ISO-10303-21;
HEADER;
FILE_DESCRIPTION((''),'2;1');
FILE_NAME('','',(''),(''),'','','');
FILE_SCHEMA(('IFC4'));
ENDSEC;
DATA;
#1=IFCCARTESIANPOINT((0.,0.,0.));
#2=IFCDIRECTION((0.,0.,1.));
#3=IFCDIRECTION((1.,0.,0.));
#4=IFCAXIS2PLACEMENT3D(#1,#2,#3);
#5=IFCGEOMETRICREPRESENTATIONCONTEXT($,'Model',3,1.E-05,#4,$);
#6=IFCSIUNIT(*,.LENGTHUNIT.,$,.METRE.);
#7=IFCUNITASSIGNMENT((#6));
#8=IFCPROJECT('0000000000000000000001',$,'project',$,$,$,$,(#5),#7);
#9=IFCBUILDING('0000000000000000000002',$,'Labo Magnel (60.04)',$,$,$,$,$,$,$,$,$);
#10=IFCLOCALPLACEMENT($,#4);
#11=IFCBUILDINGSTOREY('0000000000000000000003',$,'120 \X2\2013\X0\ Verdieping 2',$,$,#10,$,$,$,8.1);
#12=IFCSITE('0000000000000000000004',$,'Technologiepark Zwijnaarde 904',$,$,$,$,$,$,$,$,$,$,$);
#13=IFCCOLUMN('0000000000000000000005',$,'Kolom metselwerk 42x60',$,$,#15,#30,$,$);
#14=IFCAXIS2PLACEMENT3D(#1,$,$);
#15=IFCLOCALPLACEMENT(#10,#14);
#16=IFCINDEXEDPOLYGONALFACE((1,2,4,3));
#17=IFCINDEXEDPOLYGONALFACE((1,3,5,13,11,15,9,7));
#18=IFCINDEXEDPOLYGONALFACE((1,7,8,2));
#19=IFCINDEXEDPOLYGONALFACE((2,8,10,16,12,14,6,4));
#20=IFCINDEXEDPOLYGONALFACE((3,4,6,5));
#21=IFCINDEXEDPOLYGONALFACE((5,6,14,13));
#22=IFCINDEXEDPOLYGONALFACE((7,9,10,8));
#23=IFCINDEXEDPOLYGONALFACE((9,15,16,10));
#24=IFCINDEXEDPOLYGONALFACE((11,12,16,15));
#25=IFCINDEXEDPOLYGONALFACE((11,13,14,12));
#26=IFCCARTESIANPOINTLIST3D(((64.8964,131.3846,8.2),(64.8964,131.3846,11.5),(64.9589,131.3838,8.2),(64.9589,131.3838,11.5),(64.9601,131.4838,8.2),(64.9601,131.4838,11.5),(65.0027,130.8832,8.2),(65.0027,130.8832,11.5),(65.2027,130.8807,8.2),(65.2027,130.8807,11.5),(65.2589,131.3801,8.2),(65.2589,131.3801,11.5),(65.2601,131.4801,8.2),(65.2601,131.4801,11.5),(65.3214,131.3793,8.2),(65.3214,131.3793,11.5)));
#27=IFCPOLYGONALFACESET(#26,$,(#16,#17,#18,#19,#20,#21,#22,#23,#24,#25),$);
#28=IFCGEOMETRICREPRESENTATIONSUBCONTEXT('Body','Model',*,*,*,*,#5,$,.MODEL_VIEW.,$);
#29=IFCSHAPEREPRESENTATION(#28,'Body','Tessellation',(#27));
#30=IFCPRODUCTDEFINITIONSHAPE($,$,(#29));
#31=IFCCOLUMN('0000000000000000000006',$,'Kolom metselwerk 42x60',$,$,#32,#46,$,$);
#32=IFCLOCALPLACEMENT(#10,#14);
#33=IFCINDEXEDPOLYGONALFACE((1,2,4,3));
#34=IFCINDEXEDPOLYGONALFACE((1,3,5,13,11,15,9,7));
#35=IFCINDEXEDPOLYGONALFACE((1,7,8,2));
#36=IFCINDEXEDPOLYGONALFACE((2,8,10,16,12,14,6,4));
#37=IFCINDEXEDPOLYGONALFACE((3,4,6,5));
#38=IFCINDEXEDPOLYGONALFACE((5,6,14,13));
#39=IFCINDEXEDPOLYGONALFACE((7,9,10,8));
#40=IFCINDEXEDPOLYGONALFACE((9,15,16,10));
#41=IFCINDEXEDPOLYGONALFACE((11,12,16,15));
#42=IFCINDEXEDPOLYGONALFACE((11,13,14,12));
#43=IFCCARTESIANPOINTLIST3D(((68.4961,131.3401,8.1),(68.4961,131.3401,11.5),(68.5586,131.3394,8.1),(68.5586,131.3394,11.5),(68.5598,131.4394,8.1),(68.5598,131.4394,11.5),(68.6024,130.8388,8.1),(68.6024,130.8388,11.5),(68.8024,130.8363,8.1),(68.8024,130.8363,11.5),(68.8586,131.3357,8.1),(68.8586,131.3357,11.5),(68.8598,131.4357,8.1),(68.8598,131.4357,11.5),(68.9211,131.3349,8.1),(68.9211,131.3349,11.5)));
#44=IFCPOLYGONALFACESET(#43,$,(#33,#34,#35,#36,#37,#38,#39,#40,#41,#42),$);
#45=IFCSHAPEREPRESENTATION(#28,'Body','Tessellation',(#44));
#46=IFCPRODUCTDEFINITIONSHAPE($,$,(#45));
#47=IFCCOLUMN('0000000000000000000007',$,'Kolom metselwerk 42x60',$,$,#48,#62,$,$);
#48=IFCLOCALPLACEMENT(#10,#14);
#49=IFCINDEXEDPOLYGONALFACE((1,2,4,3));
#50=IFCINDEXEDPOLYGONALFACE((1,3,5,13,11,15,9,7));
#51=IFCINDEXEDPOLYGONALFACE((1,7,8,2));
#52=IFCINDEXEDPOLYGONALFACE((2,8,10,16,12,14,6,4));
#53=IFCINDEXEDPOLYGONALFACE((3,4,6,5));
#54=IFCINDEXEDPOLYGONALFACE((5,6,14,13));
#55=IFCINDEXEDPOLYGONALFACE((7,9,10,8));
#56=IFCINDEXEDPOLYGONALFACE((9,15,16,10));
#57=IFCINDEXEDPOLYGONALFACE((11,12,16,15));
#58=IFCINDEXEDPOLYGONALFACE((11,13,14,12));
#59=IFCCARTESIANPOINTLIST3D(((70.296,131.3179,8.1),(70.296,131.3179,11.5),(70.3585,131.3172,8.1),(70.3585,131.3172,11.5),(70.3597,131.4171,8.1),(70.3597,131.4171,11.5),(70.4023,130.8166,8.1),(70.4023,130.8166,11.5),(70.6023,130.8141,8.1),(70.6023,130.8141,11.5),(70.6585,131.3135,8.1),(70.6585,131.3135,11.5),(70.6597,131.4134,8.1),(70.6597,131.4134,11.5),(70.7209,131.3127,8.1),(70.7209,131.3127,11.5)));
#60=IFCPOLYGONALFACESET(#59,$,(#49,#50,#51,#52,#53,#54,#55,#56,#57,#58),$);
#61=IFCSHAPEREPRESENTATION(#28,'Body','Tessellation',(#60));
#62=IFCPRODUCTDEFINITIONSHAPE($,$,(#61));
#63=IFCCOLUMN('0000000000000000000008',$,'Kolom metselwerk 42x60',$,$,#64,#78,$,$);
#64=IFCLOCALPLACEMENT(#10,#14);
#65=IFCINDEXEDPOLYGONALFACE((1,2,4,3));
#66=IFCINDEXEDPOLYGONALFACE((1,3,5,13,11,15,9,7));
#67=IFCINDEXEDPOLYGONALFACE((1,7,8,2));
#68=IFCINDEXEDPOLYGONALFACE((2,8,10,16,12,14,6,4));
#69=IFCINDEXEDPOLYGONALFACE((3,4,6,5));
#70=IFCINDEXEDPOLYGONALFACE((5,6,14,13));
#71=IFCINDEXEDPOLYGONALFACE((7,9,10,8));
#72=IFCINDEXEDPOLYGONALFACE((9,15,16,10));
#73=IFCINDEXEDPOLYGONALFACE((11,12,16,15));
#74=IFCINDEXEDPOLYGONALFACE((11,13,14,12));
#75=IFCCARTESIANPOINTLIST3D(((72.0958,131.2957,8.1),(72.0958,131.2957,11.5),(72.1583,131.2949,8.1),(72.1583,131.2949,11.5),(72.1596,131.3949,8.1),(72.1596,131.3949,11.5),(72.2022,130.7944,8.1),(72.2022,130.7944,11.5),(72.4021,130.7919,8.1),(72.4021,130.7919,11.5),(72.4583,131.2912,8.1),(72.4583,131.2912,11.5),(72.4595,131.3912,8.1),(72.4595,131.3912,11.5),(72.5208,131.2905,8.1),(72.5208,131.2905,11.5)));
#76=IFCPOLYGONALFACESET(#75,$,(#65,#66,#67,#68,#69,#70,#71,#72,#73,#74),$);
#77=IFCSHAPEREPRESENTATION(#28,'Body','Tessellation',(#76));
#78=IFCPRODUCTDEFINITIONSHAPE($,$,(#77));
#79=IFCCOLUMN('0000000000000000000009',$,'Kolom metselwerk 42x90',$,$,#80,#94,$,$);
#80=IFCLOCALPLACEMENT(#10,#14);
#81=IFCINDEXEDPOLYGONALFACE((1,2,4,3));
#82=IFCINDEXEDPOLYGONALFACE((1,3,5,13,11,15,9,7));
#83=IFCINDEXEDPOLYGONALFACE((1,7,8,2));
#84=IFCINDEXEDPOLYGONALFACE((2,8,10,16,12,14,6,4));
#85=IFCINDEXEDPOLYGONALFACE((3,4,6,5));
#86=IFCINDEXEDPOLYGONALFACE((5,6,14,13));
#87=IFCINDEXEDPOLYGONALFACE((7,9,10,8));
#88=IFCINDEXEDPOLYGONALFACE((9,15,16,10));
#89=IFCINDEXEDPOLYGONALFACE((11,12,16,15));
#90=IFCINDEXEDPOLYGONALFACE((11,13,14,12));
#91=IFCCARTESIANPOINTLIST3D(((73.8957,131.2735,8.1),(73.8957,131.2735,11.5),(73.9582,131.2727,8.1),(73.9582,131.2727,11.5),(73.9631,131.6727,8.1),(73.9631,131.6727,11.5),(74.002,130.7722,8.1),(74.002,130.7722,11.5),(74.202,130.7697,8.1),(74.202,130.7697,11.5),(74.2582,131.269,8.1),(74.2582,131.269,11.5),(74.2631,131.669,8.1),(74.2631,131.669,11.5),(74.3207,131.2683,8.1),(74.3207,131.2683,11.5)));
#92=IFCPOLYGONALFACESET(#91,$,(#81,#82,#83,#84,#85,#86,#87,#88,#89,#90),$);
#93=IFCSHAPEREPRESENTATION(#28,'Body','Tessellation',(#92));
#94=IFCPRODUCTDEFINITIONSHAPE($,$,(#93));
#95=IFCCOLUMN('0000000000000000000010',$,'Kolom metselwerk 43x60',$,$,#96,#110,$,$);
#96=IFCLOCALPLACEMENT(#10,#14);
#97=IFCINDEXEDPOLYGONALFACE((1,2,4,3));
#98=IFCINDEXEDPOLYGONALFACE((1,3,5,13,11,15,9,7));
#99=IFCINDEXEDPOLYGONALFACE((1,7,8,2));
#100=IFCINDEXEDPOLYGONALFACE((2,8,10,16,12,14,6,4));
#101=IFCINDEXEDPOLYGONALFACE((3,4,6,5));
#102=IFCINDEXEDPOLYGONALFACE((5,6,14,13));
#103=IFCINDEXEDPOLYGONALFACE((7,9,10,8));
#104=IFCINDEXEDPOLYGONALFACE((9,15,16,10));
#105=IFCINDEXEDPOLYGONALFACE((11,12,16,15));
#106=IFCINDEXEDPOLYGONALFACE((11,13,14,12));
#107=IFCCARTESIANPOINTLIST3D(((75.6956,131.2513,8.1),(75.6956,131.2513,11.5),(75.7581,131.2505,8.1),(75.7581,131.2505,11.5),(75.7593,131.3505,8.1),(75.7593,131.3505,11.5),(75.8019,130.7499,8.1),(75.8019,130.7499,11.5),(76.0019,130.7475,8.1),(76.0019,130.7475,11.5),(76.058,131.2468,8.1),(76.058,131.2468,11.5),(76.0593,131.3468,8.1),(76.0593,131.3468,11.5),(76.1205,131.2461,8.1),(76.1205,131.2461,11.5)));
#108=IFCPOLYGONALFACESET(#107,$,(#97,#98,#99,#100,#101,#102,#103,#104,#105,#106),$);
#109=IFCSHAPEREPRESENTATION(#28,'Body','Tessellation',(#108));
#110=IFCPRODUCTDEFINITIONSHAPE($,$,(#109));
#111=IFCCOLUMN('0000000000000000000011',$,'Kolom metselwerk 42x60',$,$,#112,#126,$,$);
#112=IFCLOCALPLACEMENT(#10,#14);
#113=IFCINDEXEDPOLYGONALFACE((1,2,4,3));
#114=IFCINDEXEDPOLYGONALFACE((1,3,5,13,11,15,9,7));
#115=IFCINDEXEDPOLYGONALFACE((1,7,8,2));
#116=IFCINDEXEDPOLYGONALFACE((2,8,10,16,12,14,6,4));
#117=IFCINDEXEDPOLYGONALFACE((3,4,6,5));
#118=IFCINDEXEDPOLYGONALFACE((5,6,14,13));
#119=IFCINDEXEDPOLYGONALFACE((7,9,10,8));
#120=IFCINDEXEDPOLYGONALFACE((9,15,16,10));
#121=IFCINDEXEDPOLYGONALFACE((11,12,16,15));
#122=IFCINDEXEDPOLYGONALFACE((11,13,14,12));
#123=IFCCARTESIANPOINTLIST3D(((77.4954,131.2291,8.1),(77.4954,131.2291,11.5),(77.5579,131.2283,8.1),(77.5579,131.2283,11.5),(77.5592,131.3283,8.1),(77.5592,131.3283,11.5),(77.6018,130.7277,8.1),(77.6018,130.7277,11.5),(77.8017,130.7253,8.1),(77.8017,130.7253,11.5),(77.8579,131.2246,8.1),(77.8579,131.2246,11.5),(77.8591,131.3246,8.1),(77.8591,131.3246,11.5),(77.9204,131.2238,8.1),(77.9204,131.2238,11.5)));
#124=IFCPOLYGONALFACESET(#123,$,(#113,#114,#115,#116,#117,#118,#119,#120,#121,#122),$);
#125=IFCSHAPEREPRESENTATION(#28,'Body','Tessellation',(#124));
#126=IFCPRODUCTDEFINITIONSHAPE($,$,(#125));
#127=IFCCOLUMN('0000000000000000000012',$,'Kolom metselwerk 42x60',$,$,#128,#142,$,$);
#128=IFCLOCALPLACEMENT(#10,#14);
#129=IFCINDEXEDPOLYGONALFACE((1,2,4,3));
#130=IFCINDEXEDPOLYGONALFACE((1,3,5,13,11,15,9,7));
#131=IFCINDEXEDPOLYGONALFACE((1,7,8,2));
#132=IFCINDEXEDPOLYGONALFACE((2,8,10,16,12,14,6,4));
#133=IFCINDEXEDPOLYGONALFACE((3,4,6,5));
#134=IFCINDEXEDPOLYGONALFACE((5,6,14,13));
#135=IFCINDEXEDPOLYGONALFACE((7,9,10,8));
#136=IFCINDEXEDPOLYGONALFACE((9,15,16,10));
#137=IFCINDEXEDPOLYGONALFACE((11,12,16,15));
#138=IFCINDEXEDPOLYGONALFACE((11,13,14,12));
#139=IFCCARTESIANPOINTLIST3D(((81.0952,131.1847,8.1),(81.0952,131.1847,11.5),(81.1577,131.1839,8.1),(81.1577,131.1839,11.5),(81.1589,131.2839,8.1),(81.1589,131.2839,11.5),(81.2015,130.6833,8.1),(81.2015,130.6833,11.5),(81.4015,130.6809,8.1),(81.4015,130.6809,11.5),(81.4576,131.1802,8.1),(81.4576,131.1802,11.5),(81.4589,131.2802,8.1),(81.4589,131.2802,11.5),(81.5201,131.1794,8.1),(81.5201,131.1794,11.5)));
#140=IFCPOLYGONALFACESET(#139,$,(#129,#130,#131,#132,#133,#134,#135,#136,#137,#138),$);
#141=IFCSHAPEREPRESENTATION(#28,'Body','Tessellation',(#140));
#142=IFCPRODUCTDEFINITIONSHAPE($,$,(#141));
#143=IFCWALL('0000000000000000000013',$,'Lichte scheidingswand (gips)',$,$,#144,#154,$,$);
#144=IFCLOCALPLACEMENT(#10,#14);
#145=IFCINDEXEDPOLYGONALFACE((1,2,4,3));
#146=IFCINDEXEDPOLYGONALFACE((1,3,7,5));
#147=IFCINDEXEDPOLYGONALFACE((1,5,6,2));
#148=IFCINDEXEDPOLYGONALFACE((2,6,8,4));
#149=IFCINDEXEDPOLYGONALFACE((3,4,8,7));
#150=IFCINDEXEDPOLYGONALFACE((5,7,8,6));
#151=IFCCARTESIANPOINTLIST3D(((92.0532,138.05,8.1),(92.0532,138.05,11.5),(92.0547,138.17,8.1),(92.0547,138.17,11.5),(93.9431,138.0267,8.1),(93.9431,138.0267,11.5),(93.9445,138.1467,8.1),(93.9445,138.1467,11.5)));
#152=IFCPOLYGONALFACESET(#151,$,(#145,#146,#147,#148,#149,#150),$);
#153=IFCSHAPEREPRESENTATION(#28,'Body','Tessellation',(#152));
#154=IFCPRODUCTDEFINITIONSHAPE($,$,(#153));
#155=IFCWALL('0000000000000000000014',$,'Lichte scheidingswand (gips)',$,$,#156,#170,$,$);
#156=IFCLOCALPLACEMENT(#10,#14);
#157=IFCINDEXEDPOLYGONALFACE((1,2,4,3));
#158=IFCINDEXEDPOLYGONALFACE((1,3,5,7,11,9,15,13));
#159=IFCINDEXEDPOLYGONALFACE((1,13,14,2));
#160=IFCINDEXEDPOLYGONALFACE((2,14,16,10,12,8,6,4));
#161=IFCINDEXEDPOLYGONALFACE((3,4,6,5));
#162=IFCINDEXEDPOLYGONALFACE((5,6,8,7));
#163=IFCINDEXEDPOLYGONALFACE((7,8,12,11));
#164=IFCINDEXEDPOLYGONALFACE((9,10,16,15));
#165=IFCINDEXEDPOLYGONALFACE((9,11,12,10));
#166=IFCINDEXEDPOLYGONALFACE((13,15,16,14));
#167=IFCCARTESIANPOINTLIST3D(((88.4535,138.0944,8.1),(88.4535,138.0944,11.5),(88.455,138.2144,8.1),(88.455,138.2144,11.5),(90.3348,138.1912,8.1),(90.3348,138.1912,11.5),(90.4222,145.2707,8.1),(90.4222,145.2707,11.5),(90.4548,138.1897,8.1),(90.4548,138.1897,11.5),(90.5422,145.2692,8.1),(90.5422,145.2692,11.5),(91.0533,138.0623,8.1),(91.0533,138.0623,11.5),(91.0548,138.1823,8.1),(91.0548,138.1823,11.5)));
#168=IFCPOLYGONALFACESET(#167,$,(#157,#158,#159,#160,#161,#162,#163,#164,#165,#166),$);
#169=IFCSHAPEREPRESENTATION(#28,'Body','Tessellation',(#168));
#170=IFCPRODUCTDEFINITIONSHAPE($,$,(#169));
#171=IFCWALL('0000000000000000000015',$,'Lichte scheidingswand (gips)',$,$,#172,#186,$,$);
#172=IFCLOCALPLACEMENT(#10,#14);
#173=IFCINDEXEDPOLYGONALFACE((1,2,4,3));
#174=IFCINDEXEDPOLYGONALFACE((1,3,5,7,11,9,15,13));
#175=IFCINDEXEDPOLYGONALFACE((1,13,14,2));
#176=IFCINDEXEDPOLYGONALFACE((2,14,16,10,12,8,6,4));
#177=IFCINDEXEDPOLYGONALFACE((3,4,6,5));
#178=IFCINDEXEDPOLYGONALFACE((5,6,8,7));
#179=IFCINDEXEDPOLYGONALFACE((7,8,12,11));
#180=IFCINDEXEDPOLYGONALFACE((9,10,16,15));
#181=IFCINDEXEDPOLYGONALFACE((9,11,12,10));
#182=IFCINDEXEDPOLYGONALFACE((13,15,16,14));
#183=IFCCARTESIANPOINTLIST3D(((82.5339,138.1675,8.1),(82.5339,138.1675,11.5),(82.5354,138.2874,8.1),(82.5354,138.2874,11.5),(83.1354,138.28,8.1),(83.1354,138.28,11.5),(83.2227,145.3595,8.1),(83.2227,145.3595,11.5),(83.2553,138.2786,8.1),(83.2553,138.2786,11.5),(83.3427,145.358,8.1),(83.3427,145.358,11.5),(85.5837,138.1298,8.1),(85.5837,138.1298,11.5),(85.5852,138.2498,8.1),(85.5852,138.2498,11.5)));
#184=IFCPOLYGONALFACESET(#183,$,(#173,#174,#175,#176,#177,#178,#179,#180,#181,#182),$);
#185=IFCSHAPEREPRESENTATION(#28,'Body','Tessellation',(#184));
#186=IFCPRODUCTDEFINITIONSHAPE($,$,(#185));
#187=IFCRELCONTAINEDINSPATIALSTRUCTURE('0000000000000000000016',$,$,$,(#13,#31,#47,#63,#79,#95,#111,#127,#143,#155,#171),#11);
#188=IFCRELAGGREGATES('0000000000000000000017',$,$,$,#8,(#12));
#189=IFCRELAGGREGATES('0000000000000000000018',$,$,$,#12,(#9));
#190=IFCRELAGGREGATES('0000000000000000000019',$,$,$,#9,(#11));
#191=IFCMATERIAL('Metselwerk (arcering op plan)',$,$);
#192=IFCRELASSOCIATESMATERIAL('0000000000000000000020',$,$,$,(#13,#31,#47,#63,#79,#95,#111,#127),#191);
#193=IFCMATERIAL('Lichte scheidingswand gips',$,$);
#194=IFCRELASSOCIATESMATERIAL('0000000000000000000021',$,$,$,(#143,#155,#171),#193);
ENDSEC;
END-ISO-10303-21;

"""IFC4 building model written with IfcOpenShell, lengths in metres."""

from ifc_helpers import new_model, si_unit, frame, origin, origin_with_axes, place, context, subcontext, project, spatial, polyline, outline, extrude, material, element, save


model = new_model("IFC4")

# Units and contexts
model_context = context("Model", 3, precision=1e-05, world=origin_with_axes())
body_context = subcontext(model_context, "Body", "Model", "MODEL_VIEW")
ifc_project = project(units=[si_unit("LENGTHUNIT", "METRE")], contexts=[model_context])

# Site, building, storey
site = spatial("IfcSite", under=ifc_project, Name="Technologiepark Zwijnaarde 904")
building = spatial("IfcBuilding", under=site, Name="Labo Magnel (60.04)")
storey_placement = place(None, origin_with_axes())
storey = spatial("IfcBuildingStorey", under=building, at=storey_placement, Name="120 – Verdieping 2", Elevation=8.1)

# Columns
ifc_material_1 = material(Name="Metselwerk (arcering op plan)")
column_1_placement = place(storey_placement, frame((0.0, 0.0, 8.2), z_axis=(0.0, 0.0, 1.0), x_axis=(1.0, 0.0, 0.0)))
element("IfcColumn", 1, at=column_1_placement, inside=storey, material=ifc_material_1, Name="Kolom metselwerk 42x60", context=body_context, shape_type="SweptSolid", body=[
    extrude(outline(polyline([(65.3214, 131.3793), (65.2589, 131.3801), (65.2601, 131.4801), (64.9601, 131.4838), (64.9589, 131.3838), (64.8964, 131.3846), (65.0027, 130.8832), (65.2027, 130.8807), (65.3214, 131.3793)])), origin(), (0.0, 0.0, 1.0), 3.3),
])
column_2_placement = place(storey_placement, frame((0.0, 0.0, 8.1), z_axis=(0.0, 0.0, 1.0), x_axis=(1.0, 0.0, 0.0)))
element("IfcColumn", 2, at=column_2_placement, inside=storey, material=ifc_material_1, Name="Kolom metselwerk 42x60", context=body_context, shape_type="SweptSolid", body=[
    extrude(outline(polyline([(68.9211, 131.3349), (68.8586, 131.3357), (68.8598, 131.4357), (68.5598, 131.4394), (68.5586, 131.3394), (68.4961, 131.3401), (68.6024, 130.8388), (68.8024, 130.8363), (68.9211, 131.3349)])), origin(), (0.0, 0.0, 1.0), 3.4),
])
column_3_placement = place(storey_placement, frame((0.0, 0.0, 8.1), z_axis=(0.0, 0.0, 1.0), x_axis=(1.0, 0.0, 0.0)))
element("IfcColumn", 3, at=column_3_placement, inside=storey, material=ifc_material_1, Name="Kolom metselwerk 42x60", context=body_context, shape_type="SweptSolid", body=[
    extrude(outline(polyline([(70.7209, 131.3127), (70.6585, 131.3135), (70.6597, 131.4134), (70.3597, 131.4171), (70.3585, 131.3172), (70.296, 131.3179), (70.4023, 130.8166), (70.6023, 130.8141), (70.7209, 131.3127)])), origin(), (0.0, 0.0, 1.0), 3.4),
])
column_4_placement = place(storey_placement, frame((0.0, 0.0, 8.1), z_axis=(0.0, 0.0, 1.0), x_axis=(1.0, 0.0, 0.0)))
element("IfcColumn", 4, at=column_4_placement, inside=storey, material=ifc_material_1, Name="Kolom metselwerk 42x60", context=body_context, shape_type="SweptSolid", body=[
    extrude(outline(polyline([(72.5208, 131.2905), (72.4583, 131.2912), (72.4595, 131.3912), (72.1596, 131.3949), (72.1583, 131.2949), (72.0958, 131.2957), (72.2022, 130.7944), (72.4021, 130.7919), (72.5208, 131.2905)])), origin(), (0.0, 0.0, 1.0), 3.4),
])
column_5_placement = place(storey_placement, frame((0.0, 0.0, 8.1), z_axis=(0.0, 0.0, 1.0), x_axis=(1.0, 0.0, 0.0)))
element("IfcColumn", 5, at=column_5_placement, inside=storey, material=ifc_material_1, Name="Kolom metselwerk 42x90", context=body_context, shape_type="SweptSolid", body=[
    extrude(outline(polyline([(74.3207, 131.2683), (74.2582, 131.269), (74.2631, 131.669), (73.9631, 131.6727), (73.9582, 131.2727), (73.8957, 131.2735), (74.002, 130.7722), (74.202, 130.7697), (74.3207, 131.2683)])), origin(), (0.0, 0.0, 1.0), 3.4),
])
column_6_placement = place(storey_placement, frame((0.0, 0.0, 8.1), z_axis=(0.0, 0.0, 1.0), x_axis=(1.0, 0.0, 0.0)))
element("IfcColumn", 6, at=column_6_placement, inside=storey, material=ifc_material_1, Name="Kolom metselwerk 43x60", context=body_context, shape_type="SweptSolid", body=[
    extrude(outline(polyline([(76.1205, 131.2461), (76.058, 131.2468), (76.0593, 131.3468), (75.7593, 131.3505), (75.7581, 131.2505), (75.6956, 131.2513), (75.8019, 130.7499), (76.0019, 130.7475), (76.1205, 131.2461)])), origin(), (0.0, 0.0, 1.0), 3.4),
])
column_7_placement = place(storey_placement, frame((0.0, 0.0, 8.1), z_axis=(0.0, 0.0, 1.0), x_axis=(1.0, 0.0, 0.0)))
element("IfcColumn", 7, at=column_7_placement, inside=storey, material=ifc_material_1, Name="Kolom metselwerk 42x60", context=body_context, shape_type="SweptSolid", body=[
    extrude(outline(polyline([(77.9204, 131.2238), (77.8579, 131.2246), (77.8591, 131.3246), (77.5592, 131.3283), (77.5579, 131.2283), (77.4954, 131.2291), (77.6018, 130.7277), (77.8017, 130.7253), (77.9204, 131.2238)])), origin(), (0.0, 0.0, 1.0), 3.4),
])
column_8_placement = place(storey_placement, frame((0.0, 0.0, 8.1), z_axis=(0.0, 0.0, 1.0), x_axis=(1.0, 0.0, 0.0)))
element("IfcColumn", 8, at=column_8_placement, inside=storey, material=ifc_material_1, Name="Kolom metselwerk 42x60", context=body_context, shape_type="SweptSolid", body=[
    extrude(outline(polyline([(81.5201, 131.1794), (81.4576, 131.1802), (81.4589, 131.2802), (81.1589, 131.2839), (81.1577, 131.1839), (81.0952, 131.1847), (81.2015, 130.6833), (81.4015, 130.6809), (81.5201, 131.1794)])), origin(), (0.0, 0.0, 1.0), 3.4),
])

# Walls
ifc_material_2 = material(Name="Lichte scheidingswand gips")
wall_1_placement = place(storey_placement, frame((0.0, 0.0, 8.1), z_axis=(0.0, 0.0, 1.0), x_axis=(1.0, 0.0, 0.0)))
element("IfcWall", 9, at=wall_1_placement, inside=storey, material=ifc_material_2, Name="Lichte scheidingswand (gips)", context=body_context, shape_type="SweptSolid", body=[
    extrude(outline(polyline([(93.9445, 138.1467), (92.0547, 138.17), (92.0532, 138.05), (93.9431, 138.0267), (93.9445, 138.1467)])), origin(), (0.0, 0.0, 1.0), 3.4),
])
wall_2_placement = place(storey_placement, frame((0.0, 0.0, 8.1), z_axis=(0.0, 0.0, 1.0), x_axis=(1.0, 0.0, 0.0)))
element("IfcWall", 10, at=wall_2_placement, inside=storey, material=ifc_material_2, Name="Lichte scheidingswand (gips)", context=body_context, shape_type="SweptSolid", body=[
    extrude(outline(polyline([(88.455, 138.2144), (88.4535, 138.0944), (91.0533, 138.0623), (91.0548, 138.1823), (90.4548, 138.1897), (90.5422, 145.2692), (90.4222, 145.2707), (90.3348, 138.1912), (88.455, 138.2144)])), origin(), (0.0, 0.0, 1.0), 3.4),
])
wall_3_placement = place(storey_placement, frame((0.0, 0.0, 8.1), z_axis=(0.0, 0.0, 1.0), x_axis=(1.0, 0.0, 0.0)))
element("IfcWall", 11, at=wall_3_placement, inside=storey, material=ifc_material_2, Name="Lichte scheidingswand (gips)", context=body_context, shape_type="SweptSolid", body=[
    extrude(outline(polyline([(82.5354, 138.2874), (82.5339, 138.1675), (85.5837, 138.1298), (85.5852, 138.2498), (83.2553, 138.2786), (83.3427, 145.358), (83.2227, 145.3595), (83.1354, 138.28), (82.5354, 138.2874)])), origin(), (0.0, 0.0, 1.0), 3.4),
])

save(model, "model.ifc")
